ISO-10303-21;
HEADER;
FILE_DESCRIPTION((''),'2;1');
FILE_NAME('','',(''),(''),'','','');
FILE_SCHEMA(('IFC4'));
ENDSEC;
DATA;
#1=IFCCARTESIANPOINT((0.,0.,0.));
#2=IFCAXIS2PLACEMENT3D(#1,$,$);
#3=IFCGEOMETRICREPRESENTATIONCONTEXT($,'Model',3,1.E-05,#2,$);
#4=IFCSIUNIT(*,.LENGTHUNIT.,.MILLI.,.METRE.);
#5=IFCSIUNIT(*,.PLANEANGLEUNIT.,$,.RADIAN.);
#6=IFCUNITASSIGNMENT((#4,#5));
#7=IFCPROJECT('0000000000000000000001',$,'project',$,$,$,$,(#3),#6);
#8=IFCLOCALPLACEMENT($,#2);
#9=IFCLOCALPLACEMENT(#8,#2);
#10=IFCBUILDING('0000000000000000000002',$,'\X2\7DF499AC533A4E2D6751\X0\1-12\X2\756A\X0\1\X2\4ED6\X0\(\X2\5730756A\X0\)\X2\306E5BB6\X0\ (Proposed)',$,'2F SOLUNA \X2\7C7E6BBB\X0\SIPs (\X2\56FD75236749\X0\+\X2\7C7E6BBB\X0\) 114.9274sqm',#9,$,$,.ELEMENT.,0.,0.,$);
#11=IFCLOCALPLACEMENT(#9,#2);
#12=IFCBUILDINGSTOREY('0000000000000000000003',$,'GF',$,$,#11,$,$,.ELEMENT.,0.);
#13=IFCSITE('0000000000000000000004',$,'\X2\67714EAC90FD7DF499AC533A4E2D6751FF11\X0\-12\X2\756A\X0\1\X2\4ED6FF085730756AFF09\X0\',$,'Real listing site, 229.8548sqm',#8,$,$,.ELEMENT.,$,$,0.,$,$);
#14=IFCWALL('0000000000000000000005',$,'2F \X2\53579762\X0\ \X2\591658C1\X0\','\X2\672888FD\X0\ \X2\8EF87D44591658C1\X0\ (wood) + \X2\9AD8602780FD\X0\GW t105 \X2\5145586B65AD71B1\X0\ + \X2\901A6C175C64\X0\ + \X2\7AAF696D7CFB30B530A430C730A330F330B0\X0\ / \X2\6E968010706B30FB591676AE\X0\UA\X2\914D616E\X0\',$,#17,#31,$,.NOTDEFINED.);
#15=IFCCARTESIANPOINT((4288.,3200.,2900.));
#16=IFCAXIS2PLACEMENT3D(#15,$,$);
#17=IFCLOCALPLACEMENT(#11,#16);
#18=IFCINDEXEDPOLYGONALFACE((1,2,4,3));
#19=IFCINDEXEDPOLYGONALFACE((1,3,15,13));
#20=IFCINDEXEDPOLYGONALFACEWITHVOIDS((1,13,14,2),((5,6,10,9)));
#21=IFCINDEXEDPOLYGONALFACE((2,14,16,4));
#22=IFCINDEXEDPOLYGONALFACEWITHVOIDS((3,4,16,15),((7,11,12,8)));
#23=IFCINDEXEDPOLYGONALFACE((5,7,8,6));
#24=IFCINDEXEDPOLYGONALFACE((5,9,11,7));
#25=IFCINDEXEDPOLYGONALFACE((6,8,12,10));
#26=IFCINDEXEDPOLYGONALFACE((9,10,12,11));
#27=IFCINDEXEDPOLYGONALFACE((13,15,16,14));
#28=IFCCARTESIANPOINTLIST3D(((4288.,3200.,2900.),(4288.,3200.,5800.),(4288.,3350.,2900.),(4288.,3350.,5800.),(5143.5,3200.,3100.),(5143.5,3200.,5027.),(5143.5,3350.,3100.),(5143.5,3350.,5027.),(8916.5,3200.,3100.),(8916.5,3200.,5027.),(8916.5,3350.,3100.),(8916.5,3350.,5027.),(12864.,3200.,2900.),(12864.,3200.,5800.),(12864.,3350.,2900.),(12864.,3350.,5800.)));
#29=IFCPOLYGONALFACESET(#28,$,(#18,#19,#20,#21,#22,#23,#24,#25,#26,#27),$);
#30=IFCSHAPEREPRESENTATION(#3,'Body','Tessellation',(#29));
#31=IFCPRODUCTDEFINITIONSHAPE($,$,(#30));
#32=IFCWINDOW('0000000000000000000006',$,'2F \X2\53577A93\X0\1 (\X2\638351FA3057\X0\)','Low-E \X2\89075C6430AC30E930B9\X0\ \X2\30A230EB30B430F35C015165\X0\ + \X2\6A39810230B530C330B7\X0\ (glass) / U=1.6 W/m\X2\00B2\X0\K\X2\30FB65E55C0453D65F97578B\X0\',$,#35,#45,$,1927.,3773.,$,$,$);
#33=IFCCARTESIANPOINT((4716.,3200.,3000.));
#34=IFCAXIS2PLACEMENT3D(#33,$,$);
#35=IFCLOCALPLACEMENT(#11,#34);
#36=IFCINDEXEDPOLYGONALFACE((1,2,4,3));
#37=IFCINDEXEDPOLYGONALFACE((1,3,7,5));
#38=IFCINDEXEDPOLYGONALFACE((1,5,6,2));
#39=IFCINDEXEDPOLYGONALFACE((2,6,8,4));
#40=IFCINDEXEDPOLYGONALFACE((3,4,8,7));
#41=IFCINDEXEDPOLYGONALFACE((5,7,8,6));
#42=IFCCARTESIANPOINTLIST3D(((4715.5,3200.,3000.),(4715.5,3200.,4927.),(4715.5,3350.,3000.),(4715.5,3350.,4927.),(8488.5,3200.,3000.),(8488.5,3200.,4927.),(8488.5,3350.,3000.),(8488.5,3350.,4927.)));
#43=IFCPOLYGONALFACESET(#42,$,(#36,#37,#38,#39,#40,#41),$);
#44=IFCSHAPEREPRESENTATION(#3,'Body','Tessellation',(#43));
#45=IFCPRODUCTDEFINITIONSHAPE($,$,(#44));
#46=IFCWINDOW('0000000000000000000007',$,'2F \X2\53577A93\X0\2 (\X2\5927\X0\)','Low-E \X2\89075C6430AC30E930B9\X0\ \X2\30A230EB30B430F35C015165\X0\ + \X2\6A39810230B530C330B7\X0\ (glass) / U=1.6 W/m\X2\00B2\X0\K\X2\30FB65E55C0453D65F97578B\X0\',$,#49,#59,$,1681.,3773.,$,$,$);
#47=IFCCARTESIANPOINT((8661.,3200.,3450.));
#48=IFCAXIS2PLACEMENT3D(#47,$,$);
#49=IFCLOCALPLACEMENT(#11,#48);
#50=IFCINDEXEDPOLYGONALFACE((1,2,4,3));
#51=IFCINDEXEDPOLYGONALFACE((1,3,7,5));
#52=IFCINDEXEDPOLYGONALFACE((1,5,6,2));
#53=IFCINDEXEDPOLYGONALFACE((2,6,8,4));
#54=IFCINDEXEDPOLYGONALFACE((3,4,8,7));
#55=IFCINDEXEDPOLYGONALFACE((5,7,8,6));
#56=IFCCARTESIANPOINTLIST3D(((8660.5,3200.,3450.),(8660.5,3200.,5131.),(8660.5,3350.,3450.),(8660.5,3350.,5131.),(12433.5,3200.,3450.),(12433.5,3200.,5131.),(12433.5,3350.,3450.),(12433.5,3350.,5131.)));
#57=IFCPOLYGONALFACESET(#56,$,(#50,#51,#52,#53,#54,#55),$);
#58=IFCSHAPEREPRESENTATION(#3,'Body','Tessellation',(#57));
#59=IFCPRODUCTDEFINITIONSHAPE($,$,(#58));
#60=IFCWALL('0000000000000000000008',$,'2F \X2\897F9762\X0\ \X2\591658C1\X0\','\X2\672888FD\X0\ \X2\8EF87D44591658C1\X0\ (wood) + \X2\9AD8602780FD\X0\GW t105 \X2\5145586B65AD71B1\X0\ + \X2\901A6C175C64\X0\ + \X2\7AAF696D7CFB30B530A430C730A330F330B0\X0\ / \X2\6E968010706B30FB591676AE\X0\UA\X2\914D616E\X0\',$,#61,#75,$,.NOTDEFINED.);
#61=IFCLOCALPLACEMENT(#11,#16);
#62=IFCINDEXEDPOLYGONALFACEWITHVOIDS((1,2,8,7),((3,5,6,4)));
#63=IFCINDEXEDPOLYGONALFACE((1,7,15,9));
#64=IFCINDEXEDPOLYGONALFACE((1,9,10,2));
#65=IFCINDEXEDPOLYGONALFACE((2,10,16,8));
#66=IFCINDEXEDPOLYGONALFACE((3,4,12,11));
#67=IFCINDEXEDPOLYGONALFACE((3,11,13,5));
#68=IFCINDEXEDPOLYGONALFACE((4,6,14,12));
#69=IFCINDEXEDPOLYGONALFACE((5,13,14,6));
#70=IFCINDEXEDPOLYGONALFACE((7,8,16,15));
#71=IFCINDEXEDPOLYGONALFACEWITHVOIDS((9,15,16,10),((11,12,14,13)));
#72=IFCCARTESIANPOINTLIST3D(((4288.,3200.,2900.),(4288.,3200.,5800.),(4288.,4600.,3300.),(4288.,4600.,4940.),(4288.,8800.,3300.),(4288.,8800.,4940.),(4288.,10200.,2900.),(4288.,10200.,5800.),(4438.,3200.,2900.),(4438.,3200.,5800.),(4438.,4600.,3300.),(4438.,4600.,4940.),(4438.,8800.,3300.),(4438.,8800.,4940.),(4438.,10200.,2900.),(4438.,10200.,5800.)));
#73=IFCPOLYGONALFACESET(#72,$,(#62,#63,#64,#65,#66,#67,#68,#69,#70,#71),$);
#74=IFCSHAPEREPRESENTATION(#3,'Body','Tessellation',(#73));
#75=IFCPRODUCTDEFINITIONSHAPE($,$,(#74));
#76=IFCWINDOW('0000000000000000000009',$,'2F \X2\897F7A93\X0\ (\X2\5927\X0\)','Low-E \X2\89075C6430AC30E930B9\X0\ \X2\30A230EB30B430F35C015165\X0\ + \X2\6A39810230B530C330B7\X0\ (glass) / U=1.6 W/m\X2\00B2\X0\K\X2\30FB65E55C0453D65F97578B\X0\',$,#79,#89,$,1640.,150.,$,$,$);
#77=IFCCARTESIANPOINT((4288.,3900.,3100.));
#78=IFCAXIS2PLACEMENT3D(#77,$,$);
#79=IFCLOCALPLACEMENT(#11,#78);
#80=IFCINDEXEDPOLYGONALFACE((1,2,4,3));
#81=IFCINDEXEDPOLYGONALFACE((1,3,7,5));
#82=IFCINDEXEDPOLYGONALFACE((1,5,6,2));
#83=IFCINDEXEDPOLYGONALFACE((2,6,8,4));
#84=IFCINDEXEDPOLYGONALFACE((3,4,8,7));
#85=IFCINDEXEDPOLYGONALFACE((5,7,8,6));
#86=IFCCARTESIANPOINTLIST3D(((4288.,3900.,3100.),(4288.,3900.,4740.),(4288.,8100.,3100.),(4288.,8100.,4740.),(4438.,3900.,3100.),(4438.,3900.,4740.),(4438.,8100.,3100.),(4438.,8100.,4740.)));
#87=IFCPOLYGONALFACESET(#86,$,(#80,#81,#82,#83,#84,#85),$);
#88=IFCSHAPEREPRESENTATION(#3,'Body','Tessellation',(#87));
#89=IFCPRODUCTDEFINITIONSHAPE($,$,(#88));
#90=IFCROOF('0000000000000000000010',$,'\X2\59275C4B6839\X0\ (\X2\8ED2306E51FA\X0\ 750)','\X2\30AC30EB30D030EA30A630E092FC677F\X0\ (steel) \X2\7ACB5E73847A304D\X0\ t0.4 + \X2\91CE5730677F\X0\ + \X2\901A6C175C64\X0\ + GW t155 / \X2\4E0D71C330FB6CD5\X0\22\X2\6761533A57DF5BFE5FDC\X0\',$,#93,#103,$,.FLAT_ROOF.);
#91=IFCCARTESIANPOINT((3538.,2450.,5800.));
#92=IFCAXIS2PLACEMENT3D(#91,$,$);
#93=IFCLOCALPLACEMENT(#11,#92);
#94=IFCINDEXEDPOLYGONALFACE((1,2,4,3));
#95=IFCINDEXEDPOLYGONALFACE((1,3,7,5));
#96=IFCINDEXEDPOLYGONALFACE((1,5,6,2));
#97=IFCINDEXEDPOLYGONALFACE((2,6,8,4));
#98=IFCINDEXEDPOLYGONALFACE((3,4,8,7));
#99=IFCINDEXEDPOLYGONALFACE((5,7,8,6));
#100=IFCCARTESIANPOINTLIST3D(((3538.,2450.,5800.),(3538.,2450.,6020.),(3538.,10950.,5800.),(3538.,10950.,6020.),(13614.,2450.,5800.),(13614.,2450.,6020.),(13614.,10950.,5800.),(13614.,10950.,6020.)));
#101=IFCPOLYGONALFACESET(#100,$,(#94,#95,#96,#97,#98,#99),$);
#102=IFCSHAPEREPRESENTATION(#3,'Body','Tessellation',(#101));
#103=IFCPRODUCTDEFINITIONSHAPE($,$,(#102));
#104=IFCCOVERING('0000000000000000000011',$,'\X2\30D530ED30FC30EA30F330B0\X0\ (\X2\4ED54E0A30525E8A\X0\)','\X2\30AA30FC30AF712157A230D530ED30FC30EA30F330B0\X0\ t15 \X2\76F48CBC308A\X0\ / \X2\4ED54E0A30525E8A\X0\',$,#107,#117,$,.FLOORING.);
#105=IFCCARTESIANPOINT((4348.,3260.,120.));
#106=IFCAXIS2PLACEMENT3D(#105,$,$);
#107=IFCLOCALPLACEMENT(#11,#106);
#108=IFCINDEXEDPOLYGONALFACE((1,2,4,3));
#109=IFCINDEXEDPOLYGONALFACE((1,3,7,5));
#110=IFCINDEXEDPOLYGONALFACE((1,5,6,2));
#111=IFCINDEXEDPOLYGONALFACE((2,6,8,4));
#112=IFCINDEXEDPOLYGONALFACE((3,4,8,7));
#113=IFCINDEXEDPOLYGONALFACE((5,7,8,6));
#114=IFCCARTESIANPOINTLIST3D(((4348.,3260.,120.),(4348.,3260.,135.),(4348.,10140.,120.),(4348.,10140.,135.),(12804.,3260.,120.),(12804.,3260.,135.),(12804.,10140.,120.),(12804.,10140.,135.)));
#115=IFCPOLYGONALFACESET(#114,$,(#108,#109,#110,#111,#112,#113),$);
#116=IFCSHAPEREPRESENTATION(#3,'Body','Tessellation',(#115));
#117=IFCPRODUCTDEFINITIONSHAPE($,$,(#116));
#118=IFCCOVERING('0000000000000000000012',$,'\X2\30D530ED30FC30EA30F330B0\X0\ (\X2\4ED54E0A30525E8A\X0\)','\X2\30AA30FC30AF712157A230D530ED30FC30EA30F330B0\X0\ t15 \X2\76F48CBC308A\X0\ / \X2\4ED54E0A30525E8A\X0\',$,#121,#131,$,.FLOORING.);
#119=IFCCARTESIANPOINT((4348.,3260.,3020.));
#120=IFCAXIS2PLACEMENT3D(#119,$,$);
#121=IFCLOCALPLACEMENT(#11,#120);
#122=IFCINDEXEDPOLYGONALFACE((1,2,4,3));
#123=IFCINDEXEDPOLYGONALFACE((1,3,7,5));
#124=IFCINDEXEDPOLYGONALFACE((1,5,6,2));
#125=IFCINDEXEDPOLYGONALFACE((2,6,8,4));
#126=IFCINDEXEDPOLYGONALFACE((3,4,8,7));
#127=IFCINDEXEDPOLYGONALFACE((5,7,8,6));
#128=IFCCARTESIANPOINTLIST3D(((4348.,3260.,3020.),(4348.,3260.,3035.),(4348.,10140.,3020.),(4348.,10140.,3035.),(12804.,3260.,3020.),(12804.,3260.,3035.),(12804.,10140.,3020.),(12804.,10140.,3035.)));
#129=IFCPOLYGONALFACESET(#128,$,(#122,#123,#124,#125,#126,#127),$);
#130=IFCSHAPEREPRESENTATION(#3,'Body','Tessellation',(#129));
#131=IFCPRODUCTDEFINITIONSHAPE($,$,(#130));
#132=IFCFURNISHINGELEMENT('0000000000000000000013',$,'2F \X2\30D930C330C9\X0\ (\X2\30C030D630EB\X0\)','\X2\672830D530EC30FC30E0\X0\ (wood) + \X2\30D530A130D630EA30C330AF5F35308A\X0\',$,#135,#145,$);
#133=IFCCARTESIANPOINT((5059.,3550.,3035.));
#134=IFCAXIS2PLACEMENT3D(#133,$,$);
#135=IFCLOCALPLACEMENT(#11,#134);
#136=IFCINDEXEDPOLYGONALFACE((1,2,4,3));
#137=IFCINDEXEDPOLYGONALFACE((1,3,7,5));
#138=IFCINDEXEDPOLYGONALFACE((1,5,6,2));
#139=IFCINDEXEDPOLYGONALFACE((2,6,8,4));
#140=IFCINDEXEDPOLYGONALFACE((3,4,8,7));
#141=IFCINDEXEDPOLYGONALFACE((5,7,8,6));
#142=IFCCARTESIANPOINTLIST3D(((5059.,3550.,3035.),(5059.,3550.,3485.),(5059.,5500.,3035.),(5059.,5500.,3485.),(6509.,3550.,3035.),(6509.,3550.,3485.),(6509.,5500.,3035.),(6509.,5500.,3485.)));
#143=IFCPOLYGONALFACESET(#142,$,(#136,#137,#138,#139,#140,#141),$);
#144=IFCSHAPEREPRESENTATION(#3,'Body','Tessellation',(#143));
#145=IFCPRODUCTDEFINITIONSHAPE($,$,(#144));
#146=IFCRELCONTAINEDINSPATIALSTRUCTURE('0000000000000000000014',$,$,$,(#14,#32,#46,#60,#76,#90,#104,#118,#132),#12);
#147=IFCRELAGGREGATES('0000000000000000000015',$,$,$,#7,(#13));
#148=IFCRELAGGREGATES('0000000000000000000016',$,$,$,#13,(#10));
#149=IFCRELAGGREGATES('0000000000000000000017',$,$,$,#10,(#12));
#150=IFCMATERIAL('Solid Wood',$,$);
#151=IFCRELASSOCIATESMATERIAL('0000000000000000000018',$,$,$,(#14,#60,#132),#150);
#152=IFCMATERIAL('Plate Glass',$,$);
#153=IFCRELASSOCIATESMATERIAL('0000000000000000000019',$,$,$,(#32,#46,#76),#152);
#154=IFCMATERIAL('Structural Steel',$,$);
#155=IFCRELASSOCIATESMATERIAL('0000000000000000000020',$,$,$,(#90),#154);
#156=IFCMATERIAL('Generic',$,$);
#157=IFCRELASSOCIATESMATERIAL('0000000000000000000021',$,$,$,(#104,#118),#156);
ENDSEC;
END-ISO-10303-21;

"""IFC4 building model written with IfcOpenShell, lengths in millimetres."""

from ifc_helpers import new_model, si_unit, frame, frame_2d, origin, place, context, project, spatial, rectangle, extrude, material, element, fill, save


model = new_model("IFC4")

# Units and contexts
model_context = context("Model", 3, precision=1e-05, world=origin())
ifc_project = project(units=[si_unit("LENGTHUNIT", "METRE", prefix="MILLI"), si_unit("PLANEANGLEUNIT", "RADIAN")], contexts=[model_context])

# Site, building, storey
site_placement = place(None, origin())
site = spatial("IfcSite", under=ifc_project, at=site_placement, Name="東京都練馬区中村１-12番1他（地番）", ObjectType="Real listing site, 229.8548sqm", CompositionType="ELEMENT", RefElevation=0.0)
building_placement = place(site_placement, origin())
building = spatial("IfcBuilding", under=site, at=building_placement, Name="練馬区中村1-12番1他(地番)の家 (Proposed)", ObjectType="2F SOLUNA 籾殻SIPs (国産杉+籾殻) 114.9274sqm", CompositionType="ELEMENT", ElevationOfRefHeight=0.0, ElevationOfTerrain=0.0)
storey_placement = place(building_placement, origin())
storey = spatial("IfcBuildingStorey", under=building, at=storey_placement, Name="GF", CompositionType="ELEMENT", Elevation=0.0)

# Shared definitions
ifc_material_1 = material(Name="Solid Wood")

# Shared definitions
ifc_material_2 = material(Name="Plate Glass")

# Wall, openings, windows
wall_1_placement = place(storey_placement, frame((4288.0, 3200.0, 2900.0)))
wall_1 = element("IfcWall", 1, at=wall_1_placement, inside=storey, material=ifc_material_1, Name="2F 南面 外壁", Description="木製 軸組外壁 (wood) + 高性能GW t105 充填断熱 + 通気層 + 窯業系サイディング / 準耐火・外皮UA配慮", PredefinedType="NOTDEFINED", context=model_context, shape_type="SweptSolid", body=[
    extrude(rectangle(XDim=8576.0, YDim=150.0, at=frame_2d((4288.0, 75.0))), frame((4288.0, 3200.0, 2900.0)), (0.0, 0.0, 1.0), 2900.0),
])
opening_1_placement = place(storey_placement, frame((4716.0, 3200.0, 3000.0)))
opening_1 = element("IfcOpeningElement", 2, at=opening_1_placement, cuts=wall_1, PredefinedType="NOTDEFINED", context=model_context, shape_type="SweptSolid", body=[
    extrude(rectangle(XDim=3773.0, YDim=150.0, at=frame_2d((1886.0, 75.0))), frame((4716.0, 3200.0, 3000.0)), (0.0, 0.0, 1.0), 1927.0),
])
opening_2_placement = place(storey_placement, frame((8661.0, 3200.0, 3450.0)))
opening_2 = element("IfcOpeningElement", 3, at=opening_2_placement, cuts=wall_1, PredefinedType="NOTDEFINED", context=model_context, shape_type="SweptSolid", body=[
    extrude(rectangle(XDim=3773.0, YDim=150.0, at=frame_2d((1886.0, 75.0))), frame((8661.0, 3200.0, 3450.0)), (0.0, 0.0, 1.0), 1681.0),
])
window_1_placement = place(storey_placement, frame((4716.0, 3200.0, 3000.0)))
window_1 = element("IfcWindow", 4, at=window_1_placement, inside=storey, material=ifc_material_2, Name="2F 南窓1 (掃出し)", Description="Low-E 複層ガラス アルゴン封入 + 樹脂サッシ (glass) / U=1.6 W/m²K・日射取得型", OverallHeight=1927.0, OverallWidth=3773.0, context=model_context, shape_type="SweptSolid", body=[
    extrude(rectangle(XDim=3773.0, YDim=150.0, at=frame_2d((1886.0, 75.0))), frame((4716.0, 3200.0, 3000.0)), (0.0, 0.0, 1.0), 1927.0),
])
fill(opening_1, window_1)
window_2_placement = place(storey_placement, frame((8661.0, 3200.0, 3450.0)))
window_2 = element("IfcWindow", 5, at=window_2_placement, inside=storey, material=ifc_material_2, Name="2F 南窓2 (大)", Description="Low-E 複層ガラス アルゴン封入 + 樹脂サッシ (glass) / U=1.6 W/m²K・日射取得型", OverallHeight=1681.0, OverallWidth=3773.0, context=model_context, shape_type="SweptSolid", body=[
    extrude(rectangle(XDim=3773.0, YDim=150.0, at=frame_2d((1886.0, 75.0))), frame((8661.0, 3200.0, 3450.0)), (0.0, 0.0, 1.0), 1681.0),
])
fill(opening_2, window_2)

# Wall, opening, window
wall_2_placement = place(storey_placement, frame((4288.0, 3200.0, 2900.0)))
wall_2 = element("IfcWall", 6, at=wall_2_placement, inside=storey, material=ifc_material_1, Name="2F 西面 外壁", Description="木製 軸組外壁 (wood) + 高性能GW t105 充填断熱 + 通気層 + 窯業系サイディング / 準耐火・外皮UA配慮", PredefinedType="NOTDEFINED", context=model_context, shape_type="SweptSolid", body=[
    extrude(rectangle(XDim=150.0, YDim=7000.0, at=frame_2d((75.0, 3500.0))), frame((4288.0, 3200.0, 2900.0)), (0.0, 0.0, 1.0), 2900.0),
])
opening_3_placement = place(storey_placement, frame((4288.0, 3900.0, 3100.0)))
opening_3 = element("IfcOpeningElement", 7, at=opening_3_placement, cuts=wall_2, PredefinedType="NOTDEFINED", context=model_context, shape_type="SweptSolid", body=[
    extrude(rectangle(XDim=150.0, YDim=4200.0, at=frame_2d((75.0, 2100.0))), frame((4288.0, 3900.0, 3100.0)), (0.0, 0.0, 1.0), 1640.0),
])
window_3_placement = place(storey_placement, frame((4288.0, 3900.0, 3100.0)))
window_3 = element("IfcWindow", 8, at=window_3_placement, inside=storey, material=ifc_material_2, Name="2F 西窓 (大)", Description="Low-E 複層ガラス アルゴン封入 + 樹脂サッシ (glass) / U=1.6 W/m²K・日射取得型", OverallHeight=1640.0, OverallWidth=150.0, context=model_context, shape_type="SweptSolid", body=[
    extrude(rectangle(XDim=150.0, YDim=4200.0, at=frame_2d((75.0, 2100.0))), frame((4288.0, 3900.0, 3100.0)), (0.0, 0.0, 1.0), 1640.0),
])
fill(opening_3, window_3)

# Roof
ifc_material_3 = material(Name="Structural Steel")
roof_placement = place(storey_placement, frame((3538.0, 2450.0, 5800.0)))
element("IfcRoof", 9, at=roof_placement, inside=storey, material=ifc_material_3, Name="大屋根 (軒の出 750)", Description="ガルバリウム鋼板 (steel) 立平葺き t0.4 + 野地板 + 通気層 + GW t155 / 不燃・法22条区域対応", PredefinedType="FLAT_ROOF", context=model_context, shape_type="SweptSolid", body=[
    extrude(rectangle(XDim=10076.0, YDim=8500.0, at=frame_2d((5038.0, 4250.0))), frame((3538.0, 2450.0, 5800.0)), (0.0, 0.0, 1.0), 220.0),
])

# Coverings
ifc_material_4 = material(Name="Generic")
covering_1_placement = place(storey_placement, frame((4348.0, 3260.0, 120.0)))
element("IfcCovering", 10, at=covering_1_placement, inside=storey, material=ifc_material_4, Name="フローリング (仕上げ床)", Description="オーク無垢フローリング t15 直貼り / 仕上げ床", PredefinedType="FLOORING", context=model_context, shape_type="SweptSolid", body=[
    extrude(rectangle(XDim=8456.0, YDim=6880.0, at=frame_2d((4228.0, 3440.0))), frame((4348.0, 3260.0, 120.0)), (0.0, 0.0, 1.0), 15.0),
])
covering_2_placement = place(storey_placement, frame((4348.0, 3260.0, 3020.0)))
element("IfcCovering", 11, at=covering_2_placement, inside=storey, material=ifc_material_4, Name="フローリング (仕上げ床)", Description="オーク無垢フローリング t15 直貼り / 仕上げ床", PredefinedType="FLOORING", context=model_context, shape_type="SweptSolid", body=[
    extrude(rectangle(XDim=8456.0, YDim=6880.0, at=frame_2d((4228.0, 3440.0))), frame((4348.0, 3260.0, 3020.0)), (0.0, 0.0, 1.0), 15.0),
])

# Furnishing element
furnishing_placement = place(storey_placement, frame((5059.0, 3550.0, 3035.0)))
element("IfcFurnishingElement", 12, at=furnishing_placement, inside=storey, material=ifc_material_1, Name="2F ベッド (ダブル)", Description="木フレーム (wood) + ファブリック張り", context=model_context, shape_type="SweptSolid", body=[
    extrude(rectangle(XDim=1450.0, YDim=1950.0, at=frame_2d((725.0, 975.0))), frame((5059.0, 3550.0, 3035.0)), (0.0, 0.0, 1.0), 450.0),
])

save(model, "model.ifc")
